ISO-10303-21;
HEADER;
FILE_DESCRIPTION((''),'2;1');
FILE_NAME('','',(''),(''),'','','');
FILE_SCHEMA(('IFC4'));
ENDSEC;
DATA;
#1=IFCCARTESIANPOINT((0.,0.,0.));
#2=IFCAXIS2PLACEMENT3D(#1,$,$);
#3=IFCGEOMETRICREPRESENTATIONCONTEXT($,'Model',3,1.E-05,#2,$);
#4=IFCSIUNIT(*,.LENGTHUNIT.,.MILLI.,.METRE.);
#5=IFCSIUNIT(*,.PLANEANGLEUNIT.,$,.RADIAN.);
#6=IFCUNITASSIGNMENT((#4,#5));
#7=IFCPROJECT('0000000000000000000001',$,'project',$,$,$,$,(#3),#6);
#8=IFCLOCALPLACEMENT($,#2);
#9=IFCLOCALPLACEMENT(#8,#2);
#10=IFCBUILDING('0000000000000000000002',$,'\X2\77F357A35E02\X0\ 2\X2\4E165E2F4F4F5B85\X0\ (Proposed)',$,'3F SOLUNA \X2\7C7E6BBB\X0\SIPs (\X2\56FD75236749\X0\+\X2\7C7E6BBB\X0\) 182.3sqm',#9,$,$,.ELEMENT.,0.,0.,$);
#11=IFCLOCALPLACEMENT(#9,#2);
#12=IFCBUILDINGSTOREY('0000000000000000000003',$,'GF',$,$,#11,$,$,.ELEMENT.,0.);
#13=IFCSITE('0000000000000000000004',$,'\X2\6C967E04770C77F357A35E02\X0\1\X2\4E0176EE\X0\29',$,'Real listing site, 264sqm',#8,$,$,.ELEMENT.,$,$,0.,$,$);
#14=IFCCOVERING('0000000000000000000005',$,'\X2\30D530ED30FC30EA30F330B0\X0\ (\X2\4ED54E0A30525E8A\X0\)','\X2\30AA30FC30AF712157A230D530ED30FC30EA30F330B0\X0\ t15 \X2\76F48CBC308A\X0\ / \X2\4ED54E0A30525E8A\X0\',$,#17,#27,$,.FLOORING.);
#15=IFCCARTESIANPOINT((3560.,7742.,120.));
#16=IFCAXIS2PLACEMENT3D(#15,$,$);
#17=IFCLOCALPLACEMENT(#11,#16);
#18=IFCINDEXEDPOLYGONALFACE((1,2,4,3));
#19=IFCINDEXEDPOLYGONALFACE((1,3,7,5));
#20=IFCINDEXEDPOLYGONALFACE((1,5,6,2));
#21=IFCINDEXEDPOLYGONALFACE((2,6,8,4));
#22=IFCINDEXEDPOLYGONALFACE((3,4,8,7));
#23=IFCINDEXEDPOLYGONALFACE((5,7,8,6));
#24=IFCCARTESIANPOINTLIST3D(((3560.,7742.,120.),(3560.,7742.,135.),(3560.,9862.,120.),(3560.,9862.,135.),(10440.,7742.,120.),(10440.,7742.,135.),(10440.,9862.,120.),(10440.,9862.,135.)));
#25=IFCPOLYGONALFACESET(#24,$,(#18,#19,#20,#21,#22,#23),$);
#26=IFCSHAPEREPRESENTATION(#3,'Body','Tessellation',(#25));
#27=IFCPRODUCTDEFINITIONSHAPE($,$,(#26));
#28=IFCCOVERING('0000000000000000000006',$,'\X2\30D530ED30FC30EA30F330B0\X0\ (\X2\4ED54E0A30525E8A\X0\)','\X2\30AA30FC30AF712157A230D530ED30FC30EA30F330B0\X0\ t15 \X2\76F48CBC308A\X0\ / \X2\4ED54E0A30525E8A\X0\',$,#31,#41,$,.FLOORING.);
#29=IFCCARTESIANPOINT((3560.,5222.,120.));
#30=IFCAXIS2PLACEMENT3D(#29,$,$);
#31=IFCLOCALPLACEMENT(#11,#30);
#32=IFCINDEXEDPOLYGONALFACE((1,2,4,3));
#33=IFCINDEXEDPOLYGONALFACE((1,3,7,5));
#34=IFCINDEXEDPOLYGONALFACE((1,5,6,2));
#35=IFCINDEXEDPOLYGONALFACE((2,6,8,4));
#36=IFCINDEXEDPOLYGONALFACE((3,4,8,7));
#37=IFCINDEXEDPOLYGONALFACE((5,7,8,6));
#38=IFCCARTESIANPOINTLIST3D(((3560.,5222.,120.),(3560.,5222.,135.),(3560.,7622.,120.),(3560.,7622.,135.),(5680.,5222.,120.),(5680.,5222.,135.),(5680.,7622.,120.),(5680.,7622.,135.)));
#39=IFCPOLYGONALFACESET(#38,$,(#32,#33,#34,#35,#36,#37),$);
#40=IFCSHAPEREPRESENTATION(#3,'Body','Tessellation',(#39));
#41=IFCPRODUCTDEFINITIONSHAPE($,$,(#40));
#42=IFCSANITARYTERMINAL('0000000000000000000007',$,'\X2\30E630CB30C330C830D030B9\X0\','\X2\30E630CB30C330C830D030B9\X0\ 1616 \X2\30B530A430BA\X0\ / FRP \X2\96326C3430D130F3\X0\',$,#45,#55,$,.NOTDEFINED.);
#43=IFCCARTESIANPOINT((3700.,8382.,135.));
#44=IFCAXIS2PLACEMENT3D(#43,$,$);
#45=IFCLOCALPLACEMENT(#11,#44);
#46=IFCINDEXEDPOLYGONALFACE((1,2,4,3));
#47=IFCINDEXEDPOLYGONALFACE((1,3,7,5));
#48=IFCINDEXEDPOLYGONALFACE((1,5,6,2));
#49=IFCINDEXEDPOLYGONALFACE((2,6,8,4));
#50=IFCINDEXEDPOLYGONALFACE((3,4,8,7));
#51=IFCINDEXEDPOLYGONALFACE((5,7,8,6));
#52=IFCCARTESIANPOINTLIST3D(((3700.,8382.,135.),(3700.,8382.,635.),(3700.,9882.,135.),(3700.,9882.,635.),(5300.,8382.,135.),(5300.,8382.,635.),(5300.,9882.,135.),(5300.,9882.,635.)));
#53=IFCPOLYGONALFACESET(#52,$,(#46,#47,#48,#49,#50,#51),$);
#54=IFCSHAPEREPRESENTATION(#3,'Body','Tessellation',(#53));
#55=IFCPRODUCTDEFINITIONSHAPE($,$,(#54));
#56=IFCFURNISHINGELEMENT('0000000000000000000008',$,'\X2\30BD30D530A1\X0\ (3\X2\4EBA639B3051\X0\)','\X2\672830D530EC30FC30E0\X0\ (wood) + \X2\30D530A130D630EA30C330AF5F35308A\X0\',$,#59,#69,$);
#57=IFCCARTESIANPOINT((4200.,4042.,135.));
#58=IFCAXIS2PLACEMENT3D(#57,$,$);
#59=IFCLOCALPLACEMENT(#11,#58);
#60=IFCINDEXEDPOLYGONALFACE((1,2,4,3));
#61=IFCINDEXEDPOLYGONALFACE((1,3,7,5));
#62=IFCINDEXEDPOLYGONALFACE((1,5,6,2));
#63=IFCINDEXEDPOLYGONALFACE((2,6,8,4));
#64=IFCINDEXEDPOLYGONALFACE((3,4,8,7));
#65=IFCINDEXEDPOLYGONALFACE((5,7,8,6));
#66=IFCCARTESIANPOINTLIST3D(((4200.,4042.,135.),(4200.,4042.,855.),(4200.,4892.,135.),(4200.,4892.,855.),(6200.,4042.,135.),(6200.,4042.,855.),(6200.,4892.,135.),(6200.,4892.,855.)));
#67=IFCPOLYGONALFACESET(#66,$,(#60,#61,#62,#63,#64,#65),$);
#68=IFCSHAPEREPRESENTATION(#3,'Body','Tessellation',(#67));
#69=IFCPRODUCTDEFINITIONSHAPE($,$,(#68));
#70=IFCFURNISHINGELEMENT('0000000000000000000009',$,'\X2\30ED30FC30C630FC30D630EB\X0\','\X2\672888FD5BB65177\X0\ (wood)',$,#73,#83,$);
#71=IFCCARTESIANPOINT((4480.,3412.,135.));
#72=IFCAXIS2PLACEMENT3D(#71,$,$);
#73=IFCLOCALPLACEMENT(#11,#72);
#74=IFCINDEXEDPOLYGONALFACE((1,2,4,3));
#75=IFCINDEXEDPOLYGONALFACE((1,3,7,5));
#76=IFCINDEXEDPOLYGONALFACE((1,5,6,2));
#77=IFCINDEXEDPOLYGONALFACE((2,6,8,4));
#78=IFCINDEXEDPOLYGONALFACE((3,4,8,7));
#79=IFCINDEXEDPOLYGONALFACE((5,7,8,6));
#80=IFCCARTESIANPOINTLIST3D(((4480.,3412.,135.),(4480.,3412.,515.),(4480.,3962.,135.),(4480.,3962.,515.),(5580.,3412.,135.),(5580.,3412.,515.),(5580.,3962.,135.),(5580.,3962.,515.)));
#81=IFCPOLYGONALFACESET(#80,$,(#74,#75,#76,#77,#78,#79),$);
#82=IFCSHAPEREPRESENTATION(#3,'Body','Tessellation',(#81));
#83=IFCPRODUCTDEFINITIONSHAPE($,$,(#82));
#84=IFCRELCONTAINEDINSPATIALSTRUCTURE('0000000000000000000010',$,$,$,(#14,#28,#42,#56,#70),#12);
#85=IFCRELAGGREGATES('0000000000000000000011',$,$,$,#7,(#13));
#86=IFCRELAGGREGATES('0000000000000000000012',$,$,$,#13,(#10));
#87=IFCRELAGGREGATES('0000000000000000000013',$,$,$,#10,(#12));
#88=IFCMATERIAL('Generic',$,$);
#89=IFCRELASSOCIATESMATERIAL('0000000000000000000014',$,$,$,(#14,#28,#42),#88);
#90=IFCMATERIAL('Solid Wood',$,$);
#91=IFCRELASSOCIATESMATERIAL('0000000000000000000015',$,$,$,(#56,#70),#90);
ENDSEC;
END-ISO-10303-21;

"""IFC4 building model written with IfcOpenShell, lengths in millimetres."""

from ifc_helpers import new_model, si_unit, frame, frame_2d, origin, place, context, project, spatial, rectangle, extrude, material, element, save


model = new_model("IFC4")

# Units and contexts
model_context = context("Model", 3, precision=1e-05, world=origin())
ifc_project = project(units=[si_unit("LENGTHUNIT", "METRE", prefix="MILLI"), si_unit("PLANEANGLEUNIT", "RADIAN")], contexts=[model_context])

# Site, building, storey
site_placement = place(None, origin())
site = spatial("IfcSite", under=ifc_project, at=site_placement, Name="沖縄県石垣市1丁目29", ObjectType="Real listing site, 264sqm", CompositionType="ELEMENT", RefElevation=0.0)
building_placement = place(site_placement, origin())
building = spatial("IfcBuilding", under=site, at=building_placement, Name="石垣市 2世帯住宅 (Proposed)", ObjectType="3F SOLUNA 籾殻SIPs (国産杉+籾殻) 182.3sqm", CompositionType="ELEMENT", ElevationOfRefHeight=0.0, ElevationOfTerrain=0.0)
storey_placement = place(building_placement, origin())
storey = spatial("IfcBuildingStorey", under=building, at=storey_placement, Name="GF", CompositionType="ELEMENT", Elevation=0.0)

# Shared definitions
ifc_material_1 = material(Name="Solid Wood")

# Coverings
ifc_material_2 = material(Name="Generic")
covering_1_placement = place(storey_placement, frame((3560.0, 7742.0, 120.0)))
element("IfcCovering", 1, at=covering_1_placement, inside=storey, material=ifc_material_2, Name="フローリング (仕上げ床)", Description="オーク無垢フローリング t15 直貼り / 仕上げ床", PredefinedType="FLOORING", context=model_context, shape_type="SweptSolid", body=[
    extrude(rectangle(XDim=6880.0, YDim=2120.0, at=frame_2d((3440.0, 1060.0))), frame((3560.0, 7742.0, 120.0)), (0.0, 0.0, 1.0), 15.0),
])
covering_2_placement = place(storey_placement, frame((3560.0, 5222.0, 120.0)))
element("IfcCovering", 2, at=covering_2_placement, inside=storey, material=ifc_material_2, Name="フローリング (仕上げ床)", Description="オーク無垢フローリング t15 直貼り / 仕上げ床", PredefinedType="FLOORING", context=model_context, shape_type="SweptSolid", body=[
    extrude(rectangle(XDim=2120.0, YDim=2400.0, at=frame_2d((1060.0, 1200.0))), frame((3560.0, 5222.0, 120.0)), (0.0, 0.0, 1.0), 15.0),
])

# Sanitary terminal
sanitary_terminal_placement = place(storey_placement, frame((3700.0, 8382.0, 135.0)))
element("IfcSanitaryTerminal", 3, at=sanitary_terminal_placement, inside=storey, material=ifc_material_2, Name="ユニットバス", Description="ユニットバス 1616 サイズ / FRP 防水パン", PredefinedType="NOTDEFINED", context=model_context, shape_type="SweptSolid", body=[
    extrude(rectangle(XDim=1600.0, YDim=1500.0, at=frame_2d((800.0, 750.0))), frame((3700.0, 8382.0, 135.0)), (0.0, 0.0, 1.0), 500.0),
])

# Furnishing elements
furnishing_1_placement = place(storey_placement, frame((4200.0, 4042.0, 135.0)))
element("IfcFurnishingElement", 4, at=furnishing_1_placement, inside=storey, material=ifc_material_1, Name="ソファ (3人掛け)", Description="木フレーム (wood) + ファブリック張り", context=model_context, shape_type="SweptSolid", body=[
    extrude(rectangle(XDim=2000.0, YDim=850.0, at=frame_2d((1000.0, 425.0))), frame((4200.0, 4042.0, 135.0)), (0.0, 0.0, 1.0), 720.0),
])
furnishing_2_placement = place(storey_placement, frame((4480.0, 3412.0, 135.0)))
element("IfcFurnishingElement", 5, at=furnishing_2_placement, inside=storey, material=ifc_material_1, Name="ローテーブル", Description="木製家具 (wood)", context=model_context, shape_type="SweptSolid", body=[
    extrude(rectangle(XDim=1100.0, YDim=550.0, at=frame_2d((550.0, 275.0))), frame((4480.0, 3412.0, 135.0)), (0.0, 0.0, 1.0), 380.0),
])

save(model, "model.ifc")
